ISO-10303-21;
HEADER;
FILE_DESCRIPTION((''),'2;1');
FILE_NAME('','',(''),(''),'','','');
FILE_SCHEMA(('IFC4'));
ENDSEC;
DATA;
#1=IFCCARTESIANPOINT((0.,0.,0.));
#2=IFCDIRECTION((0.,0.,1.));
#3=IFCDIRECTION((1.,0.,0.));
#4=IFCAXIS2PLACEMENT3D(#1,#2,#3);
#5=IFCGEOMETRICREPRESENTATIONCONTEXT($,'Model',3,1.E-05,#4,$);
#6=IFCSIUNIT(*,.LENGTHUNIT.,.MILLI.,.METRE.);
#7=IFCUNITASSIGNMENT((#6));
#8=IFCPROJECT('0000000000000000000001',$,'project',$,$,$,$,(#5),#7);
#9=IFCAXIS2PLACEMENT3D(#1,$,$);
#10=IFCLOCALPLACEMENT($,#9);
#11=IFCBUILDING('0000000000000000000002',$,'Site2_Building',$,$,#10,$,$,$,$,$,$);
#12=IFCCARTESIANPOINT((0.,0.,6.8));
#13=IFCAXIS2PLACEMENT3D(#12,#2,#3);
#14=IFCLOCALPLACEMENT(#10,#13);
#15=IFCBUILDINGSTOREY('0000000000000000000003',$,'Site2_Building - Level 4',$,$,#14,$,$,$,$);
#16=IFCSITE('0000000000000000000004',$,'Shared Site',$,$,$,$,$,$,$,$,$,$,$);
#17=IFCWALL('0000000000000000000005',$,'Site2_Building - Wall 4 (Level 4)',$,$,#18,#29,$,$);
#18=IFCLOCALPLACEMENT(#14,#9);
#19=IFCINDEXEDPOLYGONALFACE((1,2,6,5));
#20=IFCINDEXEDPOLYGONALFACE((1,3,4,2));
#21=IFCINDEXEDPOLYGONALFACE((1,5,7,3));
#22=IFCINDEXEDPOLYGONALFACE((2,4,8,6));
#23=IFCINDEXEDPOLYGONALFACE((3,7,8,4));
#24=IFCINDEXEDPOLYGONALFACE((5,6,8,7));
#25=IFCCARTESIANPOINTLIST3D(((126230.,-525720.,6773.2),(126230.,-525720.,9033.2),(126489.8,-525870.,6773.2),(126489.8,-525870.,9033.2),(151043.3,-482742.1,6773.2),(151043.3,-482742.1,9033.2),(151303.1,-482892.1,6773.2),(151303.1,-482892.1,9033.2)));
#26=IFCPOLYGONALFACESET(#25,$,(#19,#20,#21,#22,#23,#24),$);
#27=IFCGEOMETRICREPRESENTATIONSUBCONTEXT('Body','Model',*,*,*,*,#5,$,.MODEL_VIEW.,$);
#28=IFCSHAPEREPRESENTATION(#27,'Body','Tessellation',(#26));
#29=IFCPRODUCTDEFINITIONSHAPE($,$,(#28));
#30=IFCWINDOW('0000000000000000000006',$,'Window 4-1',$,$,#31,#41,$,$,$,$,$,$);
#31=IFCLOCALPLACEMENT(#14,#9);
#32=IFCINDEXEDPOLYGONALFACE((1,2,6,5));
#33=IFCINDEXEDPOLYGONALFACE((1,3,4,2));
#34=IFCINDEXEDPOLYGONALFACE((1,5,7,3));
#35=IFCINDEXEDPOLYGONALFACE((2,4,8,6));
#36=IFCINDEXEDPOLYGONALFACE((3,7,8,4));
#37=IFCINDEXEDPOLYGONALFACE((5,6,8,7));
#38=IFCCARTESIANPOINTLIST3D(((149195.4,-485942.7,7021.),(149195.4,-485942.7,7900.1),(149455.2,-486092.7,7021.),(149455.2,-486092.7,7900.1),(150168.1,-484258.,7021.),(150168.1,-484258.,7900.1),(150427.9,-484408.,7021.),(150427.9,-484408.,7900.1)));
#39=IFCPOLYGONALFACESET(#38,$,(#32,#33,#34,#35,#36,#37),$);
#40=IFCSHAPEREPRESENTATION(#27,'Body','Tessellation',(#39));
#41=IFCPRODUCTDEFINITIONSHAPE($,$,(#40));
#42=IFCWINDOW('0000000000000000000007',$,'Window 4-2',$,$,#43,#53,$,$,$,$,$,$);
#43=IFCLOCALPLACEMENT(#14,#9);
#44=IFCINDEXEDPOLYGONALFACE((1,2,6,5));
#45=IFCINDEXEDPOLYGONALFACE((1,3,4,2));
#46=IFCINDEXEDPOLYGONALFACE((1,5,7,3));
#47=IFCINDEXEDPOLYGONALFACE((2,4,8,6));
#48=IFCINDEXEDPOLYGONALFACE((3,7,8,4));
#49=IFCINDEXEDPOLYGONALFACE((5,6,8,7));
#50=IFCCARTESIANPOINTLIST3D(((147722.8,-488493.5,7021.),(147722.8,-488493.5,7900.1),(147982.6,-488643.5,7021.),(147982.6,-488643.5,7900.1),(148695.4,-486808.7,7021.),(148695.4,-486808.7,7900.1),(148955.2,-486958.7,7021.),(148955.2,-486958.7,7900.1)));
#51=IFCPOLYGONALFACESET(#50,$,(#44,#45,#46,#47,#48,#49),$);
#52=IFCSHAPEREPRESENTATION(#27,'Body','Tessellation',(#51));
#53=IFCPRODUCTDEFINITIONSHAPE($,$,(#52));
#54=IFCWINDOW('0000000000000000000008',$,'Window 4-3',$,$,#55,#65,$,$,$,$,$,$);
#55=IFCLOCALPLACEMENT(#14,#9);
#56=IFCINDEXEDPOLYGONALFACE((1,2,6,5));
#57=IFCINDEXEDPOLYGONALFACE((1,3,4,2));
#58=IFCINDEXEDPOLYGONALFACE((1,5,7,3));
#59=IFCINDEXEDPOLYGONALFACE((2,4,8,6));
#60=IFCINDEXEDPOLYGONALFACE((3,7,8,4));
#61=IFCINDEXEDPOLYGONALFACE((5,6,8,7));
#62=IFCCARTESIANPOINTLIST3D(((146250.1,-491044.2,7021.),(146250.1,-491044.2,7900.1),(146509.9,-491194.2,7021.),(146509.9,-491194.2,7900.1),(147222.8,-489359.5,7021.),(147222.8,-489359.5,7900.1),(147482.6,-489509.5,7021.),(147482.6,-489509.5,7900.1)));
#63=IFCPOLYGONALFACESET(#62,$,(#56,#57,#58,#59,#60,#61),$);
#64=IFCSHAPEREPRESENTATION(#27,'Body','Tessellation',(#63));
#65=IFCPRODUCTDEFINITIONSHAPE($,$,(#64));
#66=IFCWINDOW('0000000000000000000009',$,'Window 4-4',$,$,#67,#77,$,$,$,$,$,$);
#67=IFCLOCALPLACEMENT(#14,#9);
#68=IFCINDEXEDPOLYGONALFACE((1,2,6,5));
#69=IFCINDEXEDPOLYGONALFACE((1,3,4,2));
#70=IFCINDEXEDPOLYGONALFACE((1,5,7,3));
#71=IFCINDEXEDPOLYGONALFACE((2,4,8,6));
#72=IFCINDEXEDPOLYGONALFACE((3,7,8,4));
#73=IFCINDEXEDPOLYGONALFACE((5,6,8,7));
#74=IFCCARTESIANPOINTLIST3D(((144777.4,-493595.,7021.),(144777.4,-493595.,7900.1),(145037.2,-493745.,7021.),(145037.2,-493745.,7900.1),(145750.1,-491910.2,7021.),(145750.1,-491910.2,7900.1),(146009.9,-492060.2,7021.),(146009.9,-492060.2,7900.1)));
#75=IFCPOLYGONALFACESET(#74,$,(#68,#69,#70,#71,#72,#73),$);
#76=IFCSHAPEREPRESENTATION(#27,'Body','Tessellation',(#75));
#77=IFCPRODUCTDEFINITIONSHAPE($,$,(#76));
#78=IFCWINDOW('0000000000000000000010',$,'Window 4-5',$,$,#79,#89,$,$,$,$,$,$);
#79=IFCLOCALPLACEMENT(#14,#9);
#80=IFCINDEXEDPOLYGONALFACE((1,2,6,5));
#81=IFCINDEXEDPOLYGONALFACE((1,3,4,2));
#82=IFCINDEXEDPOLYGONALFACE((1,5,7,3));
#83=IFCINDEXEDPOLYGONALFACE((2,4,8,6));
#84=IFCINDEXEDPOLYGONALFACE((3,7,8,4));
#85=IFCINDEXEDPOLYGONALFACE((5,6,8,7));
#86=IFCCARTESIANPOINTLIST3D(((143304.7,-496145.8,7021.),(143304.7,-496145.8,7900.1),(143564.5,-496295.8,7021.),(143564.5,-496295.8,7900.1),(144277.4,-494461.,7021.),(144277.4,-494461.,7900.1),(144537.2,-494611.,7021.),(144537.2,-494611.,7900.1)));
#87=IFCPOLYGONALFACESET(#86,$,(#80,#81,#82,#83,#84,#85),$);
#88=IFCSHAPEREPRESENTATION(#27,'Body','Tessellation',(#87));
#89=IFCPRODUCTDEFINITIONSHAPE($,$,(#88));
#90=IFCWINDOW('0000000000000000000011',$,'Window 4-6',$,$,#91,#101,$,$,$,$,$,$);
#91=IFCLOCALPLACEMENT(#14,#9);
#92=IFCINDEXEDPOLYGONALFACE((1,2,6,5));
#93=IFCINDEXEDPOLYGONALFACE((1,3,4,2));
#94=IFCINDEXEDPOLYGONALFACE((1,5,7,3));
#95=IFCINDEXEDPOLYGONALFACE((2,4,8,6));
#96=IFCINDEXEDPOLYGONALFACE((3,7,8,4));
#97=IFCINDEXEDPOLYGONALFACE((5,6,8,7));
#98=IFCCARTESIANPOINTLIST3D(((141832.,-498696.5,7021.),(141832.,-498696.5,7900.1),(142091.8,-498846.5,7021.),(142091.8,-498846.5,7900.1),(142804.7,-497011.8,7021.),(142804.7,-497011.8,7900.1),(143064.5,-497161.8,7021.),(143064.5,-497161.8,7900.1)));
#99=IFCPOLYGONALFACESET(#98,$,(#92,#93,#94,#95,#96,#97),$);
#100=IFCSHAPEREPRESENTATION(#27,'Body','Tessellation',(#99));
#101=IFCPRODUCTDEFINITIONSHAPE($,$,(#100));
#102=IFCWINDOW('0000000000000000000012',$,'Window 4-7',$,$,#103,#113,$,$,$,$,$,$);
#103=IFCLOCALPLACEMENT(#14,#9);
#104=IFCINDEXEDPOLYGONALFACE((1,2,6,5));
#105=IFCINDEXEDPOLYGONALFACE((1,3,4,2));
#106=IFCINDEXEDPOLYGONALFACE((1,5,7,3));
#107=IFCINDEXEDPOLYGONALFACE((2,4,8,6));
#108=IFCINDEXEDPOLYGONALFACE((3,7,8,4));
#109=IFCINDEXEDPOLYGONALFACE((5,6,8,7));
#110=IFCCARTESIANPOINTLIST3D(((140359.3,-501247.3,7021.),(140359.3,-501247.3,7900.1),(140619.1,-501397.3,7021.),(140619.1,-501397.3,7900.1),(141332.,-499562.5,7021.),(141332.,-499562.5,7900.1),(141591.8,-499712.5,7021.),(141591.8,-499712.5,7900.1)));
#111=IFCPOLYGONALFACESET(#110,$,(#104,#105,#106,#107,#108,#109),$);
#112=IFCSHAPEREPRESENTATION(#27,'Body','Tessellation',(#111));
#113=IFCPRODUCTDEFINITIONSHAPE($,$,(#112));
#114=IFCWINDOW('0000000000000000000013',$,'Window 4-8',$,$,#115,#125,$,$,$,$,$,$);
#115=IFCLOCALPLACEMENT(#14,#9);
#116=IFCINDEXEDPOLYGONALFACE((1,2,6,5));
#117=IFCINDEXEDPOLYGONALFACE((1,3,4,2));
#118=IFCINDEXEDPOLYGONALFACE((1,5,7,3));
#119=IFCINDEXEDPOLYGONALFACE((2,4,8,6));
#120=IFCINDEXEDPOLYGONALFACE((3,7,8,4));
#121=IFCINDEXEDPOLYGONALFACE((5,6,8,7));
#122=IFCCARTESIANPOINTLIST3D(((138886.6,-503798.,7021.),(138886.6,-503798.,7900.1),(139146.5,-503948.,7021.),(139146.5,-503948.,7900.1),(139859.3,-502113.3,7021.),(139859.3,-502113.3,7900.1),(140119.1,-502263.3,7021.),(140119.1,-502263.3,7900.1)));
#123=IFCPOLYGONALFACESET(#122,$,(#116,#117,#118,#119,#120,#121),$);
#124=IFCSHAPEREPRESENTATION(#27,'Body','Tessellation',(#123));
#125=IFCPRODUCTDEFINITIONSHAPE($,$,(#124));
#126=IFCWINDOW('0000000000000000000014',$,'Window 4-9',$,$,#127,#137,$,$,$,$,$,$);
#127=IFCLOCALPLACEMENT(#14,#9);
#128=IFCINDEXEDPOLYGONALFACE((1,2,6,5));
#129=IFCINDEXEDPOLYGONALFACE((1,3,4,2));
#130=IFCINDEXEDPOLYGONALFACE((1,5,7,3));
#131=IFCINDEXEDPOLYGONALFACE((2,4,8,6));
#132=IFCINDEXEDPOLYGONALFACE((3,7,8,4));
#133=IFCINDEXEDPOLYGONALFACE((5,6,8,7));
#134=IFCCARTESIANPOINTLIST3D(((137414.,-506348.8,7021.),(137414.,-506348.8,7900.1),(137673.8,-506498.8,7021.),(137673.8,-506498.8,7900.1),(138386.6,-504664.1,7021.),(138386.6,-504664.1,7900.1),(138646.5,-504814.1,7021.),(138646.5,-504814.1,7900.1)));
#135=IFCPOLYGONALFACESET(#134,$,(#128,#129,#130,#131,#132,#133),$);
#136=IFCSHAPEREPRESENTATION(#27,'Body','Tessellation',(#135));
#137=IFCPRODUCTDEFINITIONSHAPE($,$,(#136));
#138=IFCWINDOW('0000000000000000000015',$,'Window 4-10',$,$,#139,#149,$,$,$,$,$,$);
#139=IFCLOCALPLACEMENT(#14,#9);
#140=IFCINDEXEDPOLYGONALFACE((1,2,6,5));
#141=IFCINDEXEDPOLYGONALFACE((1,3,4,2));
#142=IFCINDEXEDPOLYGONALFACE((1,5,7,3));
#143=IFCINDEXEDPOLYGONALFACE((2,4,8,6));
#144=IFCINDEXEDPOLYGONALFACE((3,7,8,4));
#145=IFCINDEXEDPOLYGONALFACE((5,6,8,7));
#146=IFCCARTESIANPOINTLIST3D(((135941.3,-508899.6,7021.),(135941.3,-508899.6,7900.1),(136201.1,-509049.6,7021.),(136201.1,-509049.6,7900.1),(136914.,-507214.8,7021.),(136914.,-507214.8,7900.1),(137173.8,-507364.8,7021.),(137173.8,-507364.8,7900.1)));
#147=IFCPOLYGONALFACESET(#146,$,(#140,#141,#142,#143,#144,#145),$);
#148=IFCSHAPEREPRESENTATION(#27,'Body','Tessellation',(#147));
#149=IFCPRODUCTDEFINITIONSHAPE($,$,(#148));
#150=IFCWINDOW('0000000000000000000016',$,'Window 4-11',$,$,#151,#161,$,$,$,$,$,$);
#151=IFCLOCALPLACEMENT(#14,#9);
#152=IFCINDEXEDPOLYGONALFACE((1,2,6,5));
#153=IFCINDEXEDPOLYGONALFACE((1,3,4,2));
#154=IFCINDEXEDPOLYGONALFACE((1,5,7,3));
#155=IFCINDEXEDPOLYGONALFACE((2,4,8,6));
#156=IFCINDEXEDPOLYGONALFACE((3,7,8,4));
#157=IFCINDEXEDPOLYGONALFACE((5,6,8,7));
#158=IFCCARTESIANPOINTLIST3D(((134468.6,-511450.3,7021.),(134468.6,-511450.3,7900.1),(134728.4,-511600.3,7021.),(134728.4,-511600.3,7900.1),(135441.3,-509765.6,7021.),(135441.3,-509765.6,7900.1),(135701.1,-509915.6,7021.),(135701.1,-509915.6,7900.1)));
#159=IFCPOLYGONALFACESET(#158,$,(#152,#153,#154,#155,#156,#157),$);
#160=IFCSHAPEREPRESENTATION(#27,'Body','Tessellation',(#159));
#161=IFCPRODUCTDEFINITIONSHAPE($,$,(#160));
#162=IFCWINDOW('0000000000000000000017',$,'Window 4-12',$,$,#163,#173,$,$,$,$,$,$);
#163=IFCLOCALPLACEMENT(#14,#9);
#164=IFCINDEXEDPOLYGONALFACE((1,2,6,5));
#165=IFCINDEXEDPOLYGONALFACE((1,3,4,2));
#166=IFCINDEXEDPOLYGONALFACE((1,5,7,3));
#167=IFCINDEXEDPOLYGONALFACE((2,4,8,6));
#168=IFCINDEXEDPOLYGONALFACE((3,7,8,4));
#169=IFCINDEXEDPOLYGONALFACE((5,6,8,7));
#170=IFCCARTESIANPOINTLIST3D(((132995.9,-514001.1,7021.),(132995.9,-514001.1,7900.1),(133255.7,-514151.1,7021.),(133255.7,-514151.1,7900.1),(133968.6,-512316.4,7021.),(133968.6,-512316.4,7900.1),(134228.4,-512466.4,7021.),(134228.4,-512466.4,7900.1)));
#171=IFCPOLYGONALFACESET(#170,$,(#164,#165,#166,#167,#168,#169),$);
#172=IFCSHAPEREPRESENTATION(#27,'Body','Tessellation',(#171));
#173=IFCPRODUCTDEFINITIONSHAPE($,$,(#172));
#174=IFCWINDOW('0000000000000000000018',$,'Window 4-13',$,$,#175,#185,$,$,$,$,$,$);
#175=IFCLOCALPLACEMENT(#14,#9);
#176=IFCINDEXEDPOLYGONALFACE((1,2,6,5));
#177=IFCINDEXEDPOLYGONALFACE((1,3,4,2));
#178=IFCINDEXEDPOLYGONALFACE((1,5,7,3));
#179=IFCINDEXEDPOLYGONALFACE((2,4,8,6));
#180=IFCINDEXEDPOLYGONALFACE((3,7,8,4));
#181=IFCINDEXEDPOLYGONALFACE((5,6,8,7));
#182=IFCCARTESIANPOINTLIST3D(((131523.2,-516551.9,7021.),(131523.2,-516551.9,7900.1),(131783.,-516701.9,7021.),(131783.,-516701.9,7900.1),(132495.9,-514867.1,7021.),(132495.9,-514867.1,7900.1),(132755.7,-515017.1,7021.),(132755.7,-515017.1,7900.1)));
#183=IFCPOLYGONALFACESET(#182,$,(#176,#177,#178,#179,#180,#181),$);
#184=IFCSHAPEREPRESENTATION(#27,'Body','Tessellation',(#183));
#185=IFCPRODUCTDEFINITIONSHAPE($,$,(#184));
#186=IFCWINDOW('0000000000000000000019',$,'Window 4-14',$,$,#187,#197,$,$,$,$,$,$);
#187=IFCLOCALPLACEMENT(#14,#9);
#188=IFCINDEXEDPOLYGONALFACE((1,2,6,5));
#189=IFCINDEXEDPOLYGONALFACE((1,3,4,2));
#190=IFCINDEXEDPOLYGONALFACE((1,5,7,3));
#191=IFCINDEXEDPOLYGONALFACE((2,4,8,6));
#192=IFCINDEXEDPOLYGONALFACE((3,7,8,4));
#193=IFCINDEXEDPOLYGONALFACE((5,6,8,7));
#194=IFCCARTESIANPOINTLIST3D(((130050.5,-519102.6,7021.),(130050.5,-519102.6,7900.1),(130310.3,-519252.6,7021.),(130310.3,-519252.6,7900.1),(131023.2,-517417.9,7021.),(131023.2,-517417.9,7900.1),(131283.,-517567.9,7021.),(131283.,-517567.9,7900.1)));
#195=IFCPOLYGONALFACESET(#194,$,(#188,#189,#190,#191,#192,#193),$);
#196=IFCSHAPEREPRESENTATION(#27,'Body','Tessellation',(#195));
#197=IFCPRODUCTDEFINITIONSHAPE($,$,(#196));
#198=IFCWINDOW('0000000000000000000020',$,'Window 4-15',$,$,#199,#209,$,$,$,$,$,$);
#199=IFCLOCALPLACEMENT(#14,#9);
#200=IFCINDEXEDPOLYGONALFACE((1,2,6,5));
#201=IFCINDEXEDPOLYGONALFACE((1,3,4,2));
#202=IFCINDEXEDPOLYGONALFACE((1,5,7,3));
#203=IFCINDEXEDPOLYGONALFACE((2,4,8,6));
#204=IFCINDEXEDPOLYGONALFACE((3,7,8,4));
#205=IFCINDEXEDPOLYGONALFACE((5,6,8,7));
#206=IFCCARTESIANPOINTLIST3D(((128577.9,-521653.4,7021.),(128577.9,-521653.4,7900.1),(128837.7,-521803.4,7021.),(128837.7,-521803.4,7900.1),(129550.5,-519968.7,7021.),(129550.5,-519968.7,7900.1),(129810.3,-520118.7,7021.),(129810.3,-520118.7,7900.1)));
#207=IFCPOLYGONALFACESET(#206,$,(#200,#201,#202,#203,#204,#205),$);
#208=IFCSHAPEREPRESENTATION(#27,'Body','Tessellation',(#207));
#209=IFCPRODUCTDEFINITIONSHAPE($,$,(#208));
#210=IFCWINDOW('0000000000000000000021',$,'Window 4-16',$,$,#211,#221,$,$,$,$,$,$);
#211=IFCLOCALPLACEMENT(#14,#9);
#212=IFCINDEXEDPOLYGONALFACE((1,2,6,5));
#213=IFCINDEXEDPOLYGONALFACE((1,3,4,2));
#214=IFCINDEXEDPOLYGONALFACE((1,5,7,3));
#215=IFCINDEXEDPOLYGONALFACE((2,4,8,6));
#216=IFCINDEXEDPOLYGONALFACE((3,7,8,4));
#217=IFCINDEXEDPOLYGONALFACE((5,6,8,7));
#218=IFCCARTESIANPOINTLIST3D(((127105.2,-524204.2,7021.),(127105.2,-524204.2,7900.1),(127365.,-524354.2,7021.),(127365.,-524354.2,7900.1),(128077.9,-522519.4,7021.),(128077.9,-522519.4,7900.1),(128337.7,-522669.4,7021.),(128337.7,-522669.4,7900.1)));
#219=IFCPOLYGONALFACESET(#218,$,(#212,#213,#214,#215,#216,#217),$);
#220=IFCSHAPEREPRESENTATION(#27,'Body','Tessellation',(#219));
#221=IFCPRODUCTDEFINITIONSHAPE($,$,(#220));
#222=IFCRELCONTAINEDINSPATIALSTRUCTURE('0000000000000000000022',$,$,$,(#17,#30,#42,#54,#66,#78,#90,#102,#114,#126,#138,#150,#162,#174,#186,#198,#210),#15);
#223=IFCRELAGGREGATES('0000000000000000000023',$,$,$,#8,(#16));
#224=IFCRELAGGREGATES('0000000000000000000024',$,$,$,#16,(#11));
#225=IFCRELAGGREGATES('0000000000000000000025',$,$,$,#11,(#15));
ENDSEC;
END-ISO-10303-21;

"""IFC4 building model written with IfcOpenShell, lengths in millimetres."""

from ifc_helpers import new_model, si_unit, frame, origin, origin_with_axes, place, context, subcontext, project, spatial, indexed_curve, outline, extrude, element, save


model = new_model("IFC4")

# Units and contexts
model_context = context("Model", 3, precision=1e-05, world=origin_with_axes())
body_context = subcontext(model_context, "Body", "Model", "MODEL_VIEW")
ifc_project = project(units=[si_unit("LENGTHUNIT", "METRE", prefix="MILLI")], contexts=[model_context])

# Site, building, storey
site = spatial("IfcSite", under=ifc_project, Name="Shared Site")
building_placement = place(None, origin())
building = spatial("IfcBuilding", under=site, at=building_placement, Name="Site2_Building")
storey_placement = place(building_placement, frame((0.0, 0.0, 6.8), z_axis=(0.0, 0.0, 1.0), x_axis=(1.0, 0.0, 0.0)))
storey = spatial("IfcBuildingStorey", under=building, at=storey_placement, Name="Site2_Building - Level 4")

# Wall
wall_1_placement = place(storey_placement, frame((151043.3, -482742.1, 6773.2), z_axis=(0.0, 0.0, 1.0), x_axis=(-0.5, -0.866025, 0.0)))
element("IfcWall", 1, at=wall_1_placement, inside=storey, Name="Site2_Building - Wall 4 (Level 4)", context=body_context, shape_type="SweptSolid", body=[
    extrude(outline(indexed_curve([(0.0, 0.0), (0.0, 300.0), (49626.6, 300.0), (49626.6, 0.0), (0.0, 0.0)], self_intersect=False)), origin_with_axes(), (0.0, 0.0, 1.0), 2260.0),
])

# Windows
for number, where, z_axis, x_axis, name in (
    (2, (150168.1, -484258.0, 7021.0), (0.0, 0.0, 1.0), (-0.5, -0.866025, 0.0), "Window 4-1"),
    (3, (148695.4, -486808.7, 7021.0), (0.0, 0.0, 1.0), (-0.5, -0.866025, 0.0), "Window 4-2"),
    (4, (147222.8, -489359.5, 7021.0), (0.0, 0.0, 1.0), (-0.5, -0.866025, 0.0), "Window 4-3"),
    (5, (145750.1, -491910.2, 7021.0), (0.0, 0.0, 1.0), (-0.5, -0.866025, 0.0), "Window 4-4"),
    (6, (144277.4, -494461.0, 7021.0), (0.0, 0.0, 1.0), (-0.5, -0.866025, 0.0), "Window 4-5"),
    (7, (142804.7, -497011.8, 7021.0), (0.0, 0.0, 1.0), (-0.5, -0.866025, 0.0), "Window 4-6"),
    (8, (141332.0, -499562.5, 7021.0), (0.0, 0.0, 1.0), (-0.5, -0.866025, 0.0), "Window 4-7"),
    (9, (139859.3, -502113.3, 7021.0), (0.0, 0.0, 1.0), (-0.5, -0.866025, 0.0), "Window 4-8"),
    (10, (138386.6, -504664.1, 7021.0), (0.0, 0.0, 1.0), (-0.5, -0.866025, 0.0), "Window 4-9"),
    (11, (136914.0, -507214.8, 7021.0), (0.0, 0.0, 1.0), (-0.5, -0.866025, 0.0), "Window 4-10"),
    (12, (135441.3, -509765.6, 7021.0), (0.0, 0.0, 1.0), (-0.5, -0.866025, 0.0), "Window 4-11"),
    (13, (133968.6, -512316.4, 7021.0), (0.0, 0.0, 1.0), (-0.5, -0.866025, 0.0), "Window 4-12"),
    (14, (132495.9, -514867.1, 7021.0), (0.0, 0.0, 1.0), (-0.5, -0.866025, 0.0), "Window 4-13"),
    (15, (131023.2, -517417.9, 7021.0), (0.0, 0.0, 1.0), (-0.5, -0.866025, 0.0), "Window 4-14"),
    (16, (129550.5, -519968.7, 7021.0), (0.0, 0.0, 1.0), (-0.5, -0.866025, 0.0), "Window 4-15"),
    (17, (128077.9, -522519.4, 7021.0), (0.0, 0.0, 1.0), (-0.5, -0.866025, 0.0), "Window 4-16"),
):
    element("IfcWindow", number, at=place(storey_placement, frame(where, z_axis=z_axis, x_axis=x_axis)), inside=storey, Name=name, context=body_context, shape_type="SweptSolid", body=[
        extrude(outline(indexed_curve([(0.0, 0.0), (0.0, 300.0), (1945.4, 300.0), (1945.4, 0.0), (0.0, 0.0)], self_intersect=False)), origin_with_axes(), (0.0, 0.0, 1.0), 879.1),
    ])

save(model, "model.ifc")
